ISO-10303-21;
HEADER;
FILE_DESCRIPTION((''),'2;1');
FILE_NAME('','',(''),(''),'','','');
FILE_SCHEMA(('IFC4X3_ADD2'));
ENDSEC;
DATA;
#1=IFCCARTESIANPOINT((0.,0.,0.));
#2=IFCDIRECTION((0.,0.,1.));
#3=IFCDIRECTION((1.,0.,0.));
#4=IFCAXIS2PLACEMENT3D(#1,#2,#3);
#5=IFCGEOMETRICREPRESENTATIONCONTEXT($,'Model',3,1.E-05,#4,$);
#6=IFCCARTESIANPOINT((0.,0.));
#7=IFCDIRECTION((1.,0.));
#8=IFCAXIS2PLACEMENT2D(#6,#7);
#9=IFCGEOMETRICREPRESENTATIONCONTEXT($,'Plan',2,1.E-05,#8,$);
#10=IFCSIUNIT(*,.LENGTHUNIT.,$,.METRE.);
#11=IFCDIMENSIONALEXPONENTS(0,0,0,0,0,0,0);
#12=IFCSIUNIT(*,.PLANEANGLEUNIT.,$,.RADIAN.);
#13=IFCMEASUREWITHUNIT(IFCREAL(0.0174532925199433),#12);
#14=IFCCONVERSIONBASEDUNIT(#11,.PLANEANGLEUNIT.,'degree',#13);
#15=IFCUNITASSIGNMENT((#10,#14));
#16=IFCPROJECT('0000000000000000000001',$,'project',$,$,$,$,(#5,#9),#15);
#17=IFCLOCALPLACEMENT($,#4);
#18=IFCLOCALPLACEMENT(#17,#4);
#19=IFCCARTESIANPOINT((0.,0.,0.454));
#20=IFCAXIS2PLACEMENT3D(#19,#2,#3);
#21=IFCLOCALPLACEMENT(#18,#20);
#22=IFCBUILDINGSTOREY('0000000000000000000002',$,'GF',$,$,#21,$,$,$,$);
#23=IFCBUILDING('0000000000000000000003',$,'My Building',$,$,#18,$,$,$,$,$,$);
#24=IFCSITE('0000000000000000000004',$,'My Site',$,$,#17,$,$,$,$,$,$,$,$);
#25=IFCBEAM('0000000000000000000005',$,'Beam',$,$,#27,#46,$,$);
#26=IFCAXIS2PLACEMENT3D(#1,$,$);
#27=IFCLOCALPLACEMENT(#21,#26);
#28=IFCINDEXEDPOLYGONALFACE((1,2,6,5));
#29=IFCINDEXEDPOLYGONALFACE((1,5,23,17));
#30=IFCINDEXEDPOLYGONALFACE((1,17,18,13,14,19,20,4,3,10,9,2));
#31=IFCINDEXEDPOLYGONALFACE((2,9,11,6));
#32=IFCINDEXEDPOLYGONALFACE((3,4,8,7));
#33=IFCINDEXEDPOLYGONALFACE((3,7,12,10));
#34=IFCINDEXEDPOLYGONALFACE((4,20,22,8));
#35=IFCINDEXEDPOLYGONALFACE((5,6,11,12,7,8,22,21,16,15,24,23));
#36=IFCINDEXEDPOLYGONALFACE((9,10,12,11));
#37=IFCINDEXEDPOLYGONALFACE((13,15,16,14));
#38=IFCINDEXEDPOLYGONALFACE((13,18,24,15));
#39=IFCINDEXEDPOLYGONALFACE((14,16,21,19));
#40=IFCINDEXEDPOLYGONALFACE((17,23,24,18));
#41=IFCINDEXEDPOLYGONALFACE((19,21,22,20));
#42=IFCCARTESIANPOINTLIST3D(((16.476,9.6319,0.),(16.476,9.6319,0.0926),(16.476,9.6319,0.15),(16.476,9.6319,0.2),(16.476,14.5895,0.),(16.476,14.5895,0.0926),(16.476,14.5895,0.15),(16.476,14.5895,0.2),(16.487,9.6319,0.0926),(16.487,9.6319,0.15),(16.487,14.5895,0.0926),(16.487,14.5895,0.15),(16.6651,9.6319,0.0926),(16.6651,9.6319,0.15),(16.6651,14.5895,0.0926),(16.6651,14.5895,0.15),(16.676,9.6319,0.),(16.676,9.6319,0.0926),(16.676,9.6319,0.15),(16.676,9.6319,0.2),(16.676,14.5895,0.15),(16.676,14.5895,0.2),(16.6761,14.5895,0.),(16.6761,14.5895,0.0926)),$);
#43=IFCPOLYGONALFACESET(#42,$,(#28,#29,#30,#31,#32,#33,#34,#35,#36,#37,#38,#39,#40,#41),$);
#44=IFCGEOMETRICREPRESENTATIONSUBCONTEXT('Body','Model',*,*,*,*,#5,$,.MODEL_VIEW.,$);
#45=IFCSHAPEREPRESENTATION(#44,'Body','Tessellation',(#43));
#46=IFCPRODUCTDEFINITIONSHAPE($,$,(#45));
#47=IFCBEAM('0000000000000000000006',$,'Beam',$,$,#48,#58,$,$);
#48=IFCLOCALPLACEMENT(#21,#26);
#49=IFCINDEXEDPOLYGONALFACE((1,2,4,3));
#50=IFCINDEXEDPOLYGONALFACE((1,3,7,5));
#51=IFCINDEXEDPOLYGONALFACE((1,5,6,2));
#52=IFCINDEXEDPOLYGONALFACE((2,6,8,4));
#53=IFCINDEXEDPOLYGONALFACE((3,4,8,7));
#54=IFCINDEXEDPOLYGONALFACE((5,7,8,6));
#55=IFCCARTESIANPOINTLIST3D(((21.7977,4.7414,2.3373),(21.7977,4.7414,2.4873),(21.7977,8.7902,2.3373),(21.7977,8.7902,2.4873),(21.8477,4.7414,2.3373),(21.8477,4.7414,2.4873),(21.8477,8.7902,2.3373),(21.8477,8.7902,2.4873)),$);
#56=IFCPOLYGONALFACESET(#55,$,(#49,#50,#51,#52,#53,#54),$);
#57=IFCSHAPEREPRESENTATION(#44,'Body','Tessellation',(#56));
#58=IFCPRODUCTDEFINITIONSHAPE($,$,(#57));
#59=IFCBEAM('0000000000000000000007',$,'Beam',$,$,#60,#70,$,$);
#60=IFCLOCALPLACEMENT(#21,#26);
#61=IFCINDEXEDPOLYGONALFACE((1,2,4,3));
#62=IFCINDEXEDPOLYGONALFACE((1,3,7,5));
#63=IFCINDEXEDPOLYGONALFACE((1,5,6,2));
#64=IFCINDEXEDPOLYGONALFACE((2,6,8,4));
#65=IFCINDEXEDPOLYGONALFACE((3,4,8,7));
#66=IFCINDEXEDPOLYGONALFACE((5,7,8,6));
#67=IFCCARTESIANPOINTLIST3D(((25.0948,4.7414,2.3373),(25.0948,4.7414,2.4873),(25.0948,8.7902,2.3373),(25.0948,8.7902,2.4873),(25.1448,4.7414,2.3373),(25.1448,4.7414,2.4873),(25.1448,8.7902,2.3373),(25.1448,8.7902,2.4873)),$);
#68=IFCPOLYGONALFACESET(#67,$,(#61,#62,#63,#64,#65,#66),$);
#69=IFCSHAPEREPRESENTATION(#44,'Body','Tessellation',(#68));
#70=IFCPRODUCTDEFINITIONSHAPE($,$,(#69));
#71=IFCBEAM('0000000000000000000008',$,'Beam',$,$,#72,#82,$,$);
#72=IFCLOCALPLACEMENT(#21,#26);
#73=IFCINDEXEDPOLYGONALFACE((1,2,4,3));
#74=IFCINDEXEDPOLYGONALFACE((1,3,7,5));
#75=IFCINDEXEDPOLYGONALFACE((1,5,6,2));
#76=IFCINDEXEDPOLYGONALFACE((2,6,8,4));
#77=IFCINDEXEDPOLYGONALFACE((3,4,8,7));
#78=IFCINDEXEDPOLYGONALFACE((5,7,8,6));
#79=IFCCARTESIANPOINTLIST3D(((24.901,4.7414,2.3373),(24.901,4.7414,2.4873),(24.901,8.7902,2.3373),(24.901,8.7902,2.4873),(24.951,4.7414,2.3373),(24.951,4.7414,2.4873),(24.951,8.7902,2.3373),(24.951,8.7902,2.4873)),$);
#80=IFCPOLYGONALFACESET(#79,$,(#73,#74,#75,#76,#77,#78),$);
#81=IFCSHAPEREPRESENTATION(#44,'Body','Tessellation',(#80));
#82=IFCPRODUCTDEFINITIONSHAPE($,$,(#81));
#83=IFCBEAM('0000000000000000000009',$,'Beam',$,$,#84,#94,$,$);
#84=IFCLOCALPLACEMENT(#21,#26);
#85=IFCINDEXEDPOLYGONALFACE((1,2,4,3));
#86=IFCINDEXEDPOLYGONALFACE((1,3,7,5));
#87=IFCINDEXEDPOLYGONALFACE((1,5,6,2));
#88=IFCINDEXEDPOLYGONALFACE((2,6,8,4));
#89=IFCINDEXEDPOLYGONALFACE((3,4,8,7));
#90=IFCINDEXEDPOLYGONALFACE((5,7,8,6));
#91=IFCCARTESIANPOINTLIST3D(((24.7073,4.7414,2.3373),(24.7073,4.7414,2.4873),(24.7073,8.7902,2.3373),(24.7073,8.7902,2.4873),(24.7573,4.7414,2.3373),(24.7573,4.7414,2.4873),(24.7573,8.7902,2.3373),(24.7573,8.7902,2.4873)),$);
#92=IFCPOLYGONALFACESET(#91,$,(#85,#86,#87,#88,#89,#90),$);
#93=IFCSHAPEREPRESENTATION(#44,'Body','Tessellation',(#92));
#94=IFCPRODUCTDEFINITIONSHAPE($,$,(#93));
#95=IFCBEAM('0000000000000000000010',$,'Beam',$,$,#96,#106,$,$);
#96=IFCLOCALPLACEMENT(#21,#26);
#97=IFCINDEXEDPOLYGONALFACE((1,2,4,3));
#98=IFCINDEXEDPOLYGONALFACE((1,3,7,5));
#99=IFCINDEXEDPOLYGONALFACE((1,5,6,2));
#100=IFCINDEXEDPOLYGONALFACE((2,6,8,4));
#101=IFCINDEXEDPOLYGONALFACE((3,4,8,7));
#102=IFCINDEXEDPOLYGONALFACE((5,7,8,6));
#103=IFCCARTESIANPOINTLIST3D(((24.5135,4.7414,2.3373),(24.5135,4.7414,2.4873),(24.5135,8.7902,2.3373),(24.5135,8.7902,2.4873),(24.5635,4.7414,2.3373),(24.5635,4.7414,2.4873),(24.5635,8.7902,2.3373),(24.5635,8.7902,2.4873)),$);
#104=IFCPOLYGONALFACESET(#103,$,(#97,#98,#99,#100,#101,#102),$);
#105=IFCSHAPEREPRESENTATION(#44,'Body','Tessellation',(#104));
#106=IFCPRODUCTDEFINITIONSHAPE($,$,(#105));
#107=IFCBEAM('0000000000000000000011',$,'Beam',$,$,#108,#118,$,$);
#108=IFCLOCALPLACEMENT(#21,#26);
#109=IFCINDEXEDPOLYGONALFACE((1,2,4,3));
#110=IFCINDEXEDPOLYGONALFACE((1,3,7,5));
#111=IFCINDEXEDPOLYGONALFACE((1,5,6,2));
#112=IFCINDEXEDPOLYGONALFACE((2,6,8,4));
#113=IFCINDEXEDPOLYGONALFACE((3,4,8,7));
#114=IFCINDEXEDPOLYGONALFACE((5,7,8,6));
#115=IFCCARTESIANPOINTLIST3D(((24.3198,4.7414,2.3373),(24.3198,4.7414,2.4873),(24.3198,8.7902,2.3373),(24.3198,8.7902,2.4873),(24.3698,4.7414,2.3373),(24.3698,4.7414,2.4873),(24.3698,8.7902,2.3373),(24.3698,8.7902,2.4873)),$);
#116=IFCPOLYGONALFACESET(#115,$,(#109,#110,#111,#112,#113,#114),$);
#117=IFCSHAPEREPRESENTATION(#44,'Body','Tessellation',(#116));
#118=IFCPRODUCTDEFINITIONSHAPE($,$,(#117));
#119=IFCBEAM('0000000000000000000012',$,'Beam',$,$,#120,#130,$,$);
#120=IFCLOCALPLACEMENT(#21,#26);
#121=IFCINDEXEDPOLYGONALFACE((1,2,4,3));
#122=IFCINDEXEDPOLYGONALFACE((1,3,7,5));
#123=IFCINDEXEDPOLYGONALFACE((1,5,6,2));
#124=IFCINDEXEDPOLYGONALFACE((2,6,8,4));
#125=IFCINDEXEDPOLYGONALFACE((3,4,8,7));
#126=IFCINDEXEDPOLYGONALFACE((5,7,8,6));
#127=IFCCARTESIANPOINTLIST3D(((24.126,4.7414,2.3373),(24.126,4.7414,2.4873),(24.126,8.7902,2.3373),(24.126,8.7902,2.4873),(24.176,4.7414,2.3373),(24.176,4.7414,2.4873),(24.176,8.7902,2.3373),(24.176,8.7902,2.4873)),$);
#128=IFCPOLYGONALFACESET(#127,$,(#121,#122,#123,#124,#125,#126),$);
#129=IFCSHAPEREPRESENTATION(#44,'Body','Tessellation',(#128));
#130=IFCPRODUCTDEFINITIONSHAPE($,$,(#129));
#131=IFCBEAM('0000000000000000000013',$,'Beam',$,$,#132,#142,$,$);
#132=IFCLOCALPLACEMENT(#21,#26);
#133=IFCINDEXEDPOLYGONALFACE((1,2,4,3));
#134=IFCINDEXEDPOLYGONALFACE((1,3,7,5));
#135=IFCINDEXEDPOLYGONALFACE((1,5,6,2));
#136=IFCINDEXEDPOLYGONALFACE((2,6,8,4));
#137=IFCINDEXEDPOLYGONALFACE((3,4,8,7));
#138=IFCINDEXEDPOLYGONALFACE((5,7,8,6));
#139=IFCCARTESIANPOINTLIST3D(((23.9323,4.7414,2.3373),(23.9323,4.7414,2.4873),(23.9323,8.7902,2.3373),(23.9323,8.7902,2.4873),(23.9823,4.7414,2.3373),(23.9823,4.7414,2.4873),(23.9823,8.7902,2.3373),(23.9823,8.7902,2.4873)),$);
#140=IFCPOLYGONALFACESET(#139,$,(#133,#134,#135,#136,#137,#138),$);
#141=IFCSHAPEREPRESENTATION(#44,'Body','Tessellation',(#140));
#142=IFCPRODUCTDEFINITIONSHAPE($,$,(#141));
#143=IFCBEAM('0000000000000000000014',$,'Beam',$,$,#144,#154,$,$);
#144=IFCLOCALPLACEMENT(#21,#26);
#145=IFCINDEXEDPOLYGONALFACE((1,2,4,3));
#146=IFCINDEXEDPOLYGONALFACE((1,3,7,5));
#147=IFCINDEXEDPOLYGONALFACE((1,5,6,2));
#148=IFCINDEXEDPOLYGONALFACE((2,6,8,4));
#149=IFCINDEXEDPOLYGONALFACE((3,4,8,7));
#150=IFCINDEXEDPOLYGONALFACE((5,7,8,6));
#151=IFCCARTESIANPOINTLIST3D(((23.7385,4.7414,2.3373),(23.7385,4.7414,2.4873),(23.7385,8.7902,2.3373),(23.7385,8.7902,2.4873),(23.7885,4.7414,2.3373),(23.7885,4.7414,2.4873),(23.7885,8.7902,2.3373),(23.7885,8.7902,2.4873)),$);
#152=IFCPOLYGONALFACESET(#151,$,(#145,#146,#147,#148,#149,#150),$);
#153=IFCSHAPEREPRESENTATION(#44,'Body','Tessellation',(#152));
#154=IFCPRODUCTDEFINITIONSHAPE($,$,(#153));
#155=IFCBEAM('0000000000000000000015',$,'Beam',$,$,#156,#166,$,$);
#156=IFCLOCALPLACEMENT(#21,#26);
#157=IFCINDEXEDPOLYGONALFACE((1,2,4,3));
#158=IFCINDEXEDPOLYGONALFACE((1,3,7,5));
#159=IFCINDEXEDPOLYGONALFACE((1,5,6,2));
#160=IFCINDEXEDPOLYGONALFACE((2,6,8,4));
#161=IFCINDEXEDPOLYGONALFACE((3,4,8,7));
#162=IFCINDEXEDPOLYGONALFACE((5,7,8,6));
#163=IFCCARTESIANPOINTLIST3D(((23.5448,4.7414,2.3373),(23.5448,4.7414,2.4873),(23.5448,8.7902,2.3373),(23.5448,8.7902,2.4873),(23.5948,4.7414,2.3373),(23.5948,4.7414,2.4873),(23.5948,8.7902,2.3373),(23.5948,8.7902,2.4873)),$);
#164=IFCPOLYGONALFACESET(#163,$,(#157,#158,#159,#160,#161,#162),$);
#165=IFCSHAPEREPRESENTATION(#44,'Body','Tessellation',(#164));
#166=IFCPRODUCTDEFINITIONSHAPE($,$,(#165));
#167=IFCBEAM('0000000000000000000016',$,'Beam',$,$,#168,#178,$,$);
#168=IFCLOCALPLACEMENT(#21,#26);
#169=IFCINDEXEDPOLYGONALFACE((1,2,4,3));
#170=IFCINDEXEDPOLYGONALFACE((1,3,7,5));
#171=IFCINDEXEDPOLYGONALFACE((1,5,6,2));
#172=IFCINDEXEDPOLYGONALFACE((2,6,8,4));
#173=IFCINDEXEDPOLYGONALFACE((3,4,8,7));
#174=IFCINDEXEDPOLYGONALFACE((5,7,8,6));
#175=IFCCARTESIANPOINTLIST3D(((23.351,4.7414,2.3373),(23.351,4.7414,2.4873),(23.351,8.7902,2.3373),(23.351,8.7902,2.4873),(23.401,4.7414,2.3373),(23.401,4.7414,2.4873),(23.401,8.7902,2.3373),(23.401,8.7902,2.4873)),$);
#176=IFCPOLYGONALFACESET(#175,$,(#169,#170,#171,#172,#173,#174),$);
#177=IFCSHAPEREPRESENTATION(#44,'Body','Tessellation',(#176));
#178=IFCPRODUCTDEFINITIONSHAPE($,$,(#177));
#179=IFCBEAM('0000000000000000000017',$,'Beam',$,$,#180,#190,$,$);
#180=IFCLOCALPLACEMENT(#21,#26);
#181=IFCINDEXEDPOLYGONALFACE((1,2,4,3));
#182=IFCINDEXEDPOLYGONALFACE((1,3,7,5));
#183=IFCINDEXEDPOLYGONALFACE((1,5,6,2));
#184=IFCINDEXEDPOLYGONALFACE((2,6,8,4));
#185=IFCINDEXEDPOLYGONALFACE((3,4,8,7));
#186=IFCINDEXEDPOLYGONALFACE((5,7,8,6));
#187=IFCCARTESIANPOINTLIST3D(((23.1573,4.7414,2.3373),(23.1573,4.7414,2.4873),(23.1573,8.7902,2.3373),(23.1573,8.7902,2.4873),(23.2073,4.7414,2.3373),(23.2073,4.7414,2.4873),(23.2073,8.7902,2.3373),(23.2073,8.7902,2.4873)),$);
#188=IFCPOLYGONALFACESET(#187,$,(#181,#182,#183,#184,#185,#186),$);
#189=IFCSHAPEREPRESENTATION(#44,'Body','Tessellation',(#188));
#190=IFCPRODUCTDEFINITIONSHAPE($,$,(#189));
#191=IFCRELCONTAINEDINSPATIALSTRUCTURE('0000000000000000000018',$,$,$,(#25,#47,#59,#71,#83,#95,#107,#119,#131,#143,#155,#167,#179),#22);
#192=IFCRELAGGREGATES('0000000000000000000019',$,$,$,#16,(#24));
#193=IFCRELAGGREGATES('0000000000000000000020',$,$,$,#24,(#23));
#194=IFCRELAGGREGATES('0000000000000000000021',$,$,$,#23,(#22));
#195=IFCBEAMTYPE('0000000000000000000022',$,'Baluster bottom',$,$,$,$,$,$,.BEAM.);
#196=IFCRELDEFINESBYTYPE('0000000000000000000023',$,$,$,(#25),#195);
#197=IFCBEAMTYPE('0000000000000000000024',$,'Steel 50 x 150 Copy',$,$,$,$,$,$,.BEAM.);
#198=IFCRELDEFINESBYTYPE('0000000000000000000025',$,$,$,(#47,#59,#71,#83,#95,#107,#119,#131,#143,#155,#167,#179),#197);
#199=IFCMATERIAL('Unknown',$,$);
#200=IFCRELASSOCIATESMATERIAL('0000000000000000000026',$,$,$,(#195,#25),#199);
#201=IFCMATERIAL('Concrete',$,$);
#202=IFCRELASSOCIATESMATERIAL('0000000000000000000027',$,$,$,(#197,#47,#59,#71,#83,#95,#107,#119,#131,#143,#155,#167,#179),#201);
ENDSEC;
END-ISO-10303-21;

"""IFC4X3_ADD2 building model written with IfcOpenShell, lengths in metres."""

from ifc_helpers import new_model, entity, si_unit, converted_unit, frame, origin_with_axes, origin_2d_with_axis, place, context, subcontext, project, spatial, indexed_curve, rectangle, outline, extrude, material, material_profile, profile_set, profile_usage, type_object, element, save


model = new_model("IFC4X3_ADD2")

# Units and contexts
model_context = context("Model", 3, precision=1e-05, world=origin_with_axes())
plan_context = context("Plan", 2, precision=1e-05, world=origin_2d_with_axis())
body_context_1 = subcontext(model_context, "Body", "Model", "MODEL_VIEW")
ifc_project = project(units=[si_unit("LENGTHUNIT", "METRE"), converted_unit("PLANEANGLEUNIT", "degree", entity("IfcReal", 0.0174532925199433), si_unit("PLANEANGLEUNIT", "RADIAN"), dimensions=[0, 0, 0, 0, 0, 0, 0])], contexts=[model_context, plan_context])

# Site, building, storey
site_placement = place(None, origin_with_axes())
site = spatial("IfcSite", under=ifc_project, at=site_placement, Name="My Site")
building_placement = place(site_placement, origin_with_axes())
building = spatial("IfcBuilding", under=site, at=building_placement, Name="My Building")
storey_placement = place(building_placement, frame((0.0, 0.0, 0.454), z_axis=(0.0, 0.0, 1.0), x_axis=(1.0, 0.0, 0.0)))
storey = spatial("IfcBuildingStorey", under=building, at=storey_placement, Name="GF")

# Beams
ifc_material_1 = material(Name="Unknown")
ifc_material_profile_1 = material_profile(ifc_material_1, outline(indexed_curve([(0.0891, 0.15), (0.1, 0.15), (0.1, 0.2), (-0.1, 0.2), (-0.1, 0.15), (-0.0891, 0.15), (-0.0891, 0.0926), (-0.1, 0.0926), (-0.1, 0.0), (0.1, 0.0), (0.1, 0.0926), (0.0891, 0.0926), (0.0891, 0.15)])))
ifc_profile_set_1 = profile_set([ifc_material_profile_1])
ifc_profile_usage_1 = profile_usage(ifc_profile_set_1, cardinal=5)
beam_type_1 = type_object("IfcBeamType", Name="Baluster bottom", PredefinedType="BEAM", material=ifc_profile_set_1)
beam_1_placement = place(storey_placement, frame((16.576, 14.5895, 0.0), z_axis=(0.0, -1.0, 0.0), x_axis=(1.0, 0.0, 0.0)))
element("IfcBeam", 1, at=beam_1_placement, inside=storey, type_object=beam_type_1, material=ifc_profile_usage_1, Name="Beam", context=body_context_1, shape_type="SweptSolid", body=[
    extrude(outline(indexed_curve([(0.0891, 0.15), (0.1, 0.15), (0.1, 0.2), (-0.1, 0.2), (-0.1, 0.15), (-0.0891, 0.15), (-0.0891, 0.0926), (-0.1, 0.0926), (-0.1, 0.0), (0.1, 0.0), (0.1, 0.0926), (0.0891, 0.0926), (0.0891, 0.15)])), origin_with_axes(), (0.0, 0.0, 1.0), 4.9577),
])
ifc_material_2 = material(Name="Concrete")
ifc_material_profile_2 = material_profile(ifc_material_2, rectangle(XDim=0.05, YDim=0.15))
ifc_profile_set_2 = profile_set([ifc_material_profile_2])
ifc_profile_usage_2 = profile_usage(ifc_profile_set_2)
beam_type_2 = type_object("IfcBeamType", Name="Steel 50 x 150 Copy", PredefinedType="BEAM", material=ifc_profile_set_2)
beam_2_placement = place(storey_placement, frame((21.8227, 8.7902, 2.4123), z_axis=(0.0, -1.0, 0.0), x_axis=(1.0, 0.0, 0.0)))
element("IfcBeam", 2, at=beam_2_placement, inside=storey, type_object=beam_type_2, material=ifc_profile_usage_2, Name="Beam", context=body_context_1, shape_type="SweptSolid", body=[
    extrude(rectangle(XDim=0.05, YDim=0.15), origin_with_axes(), (0.0, 0.0, 1.0), 4.0488),
])
ifc_profile_usage_3 = profile_usage(ifc_profile_set_2)
beam_3_placement = place(storey_placement, frame((25.1198, 8.7902, 2.4123), z_axis=(0.0, -1.0, 0.0), x_axis=(1.0, 0.0, 0.0)))
element("IfcBeam", 3, at=beam_3_placement, inside=storey, type_object=beam_type_2, material=ifc_profile_usage_3, Name="Beam", context=body_context_1, shape_type="SweptSolid", body=[
    extrude(rectangle(XDim=0.05, YDim=0.15), origin_with_axes(), (0.0, 0.0, 1.0), 4.0488),
])
ifc_profile_usage_4 = profile_usage(ifc_profile_set_2)
beam_4_placement = place(storey_placement, frame((24.926, 8.7902, 2.4123), z_axis=(0.0, -1.0, 0.0), x_axis=(1.0, 0.0, 0.0)))
element("IfcBeam", 4, at=beam_4_placement, inside=storey, type_object=beam_type_2, material=ifc_profile_usage_4, Name="Beam", context=body_context_1, shape_type="SweptSolid", body=[
    extrude(rectangle(XDim=0.05, YDim=0.15), origin_with_axes(), (0.0, 0.0, 1.0), 4.0488),
])
ifc_profile_usage_5 = profile_usage(ifc_profile_set_2)
beam_5_placement = place(storey_placement, frame((24.7323, 8.7902, 2.4123), z_axis=(0.0, -1.0, 0.0), x_axis=(1.0, 0.0, 0.0)))
element("IfcBeam", 5, at=beam_5_placement, inside=storey, type_object=beam_type_2, material=ifc_profile_usage_5, Name="Beam", context=body_context_1, shape_type="SweptSolid", body=[
    extrude(rectangle(XDim=0.05, YDim=0.15), origin_with_axes(), (0.0, 0.0, 1.0), 4.0488),
])
ifc_profile_usage_6 = profile_usage(ifc_profile_set_2)
beam_6_placement = place(storey_placement, frame((24.5385, 8.7902, 2.4123), z_axis=(0.0, -1.0, 0.0), x_axis=(1.0, 0.0, 0.0)))
element("IfcBeam", 6, at=beam_6_placement, inside=storey, type_object=beam_type_2, material=ifc_profile_usage_6, Name="Beam", context=body_context_1, shape_type="SweptSolid", body=[
    extrude(rectangle(XDim=0.05, YDim=0.15), origin_with_axes(), (0.0, 0.0, 1.0), 4.0488),
])
ifc_profile_usage_7 = profile_usage(ifc_profile_set_2)
beam_7_placement = place(storey_placement, frame((24.3448, 8.7902, 2.4123), z_axis=(0.0, -1.0, 0.0), x_axis=(1.0, 0.0, 0.0)))
element("IfcBeam", 7, at=beam_7_placement, inside=storey, type_object=beam_type_2, material=ifc_profile_usage_7, Name="Beam", context=body_context_1, shape_type="SweptSolid", body=[
    extrude(rectangle(XDim=0.05, YDim=0.15), origin_with_axes(), (0.0, 0.0, 1.0), 4.0488),
])
ifc_profile_usage_8 = profile_usage(ifc_profile_set_2)
beam_8_placement = place(storey_placement, frame((24.151, 8.7902, 2.4123), z_axis=(0.0, -1.0, 0.0), x_axis=(1.0, 0.0, 0.0)))
element("IfcBeam", 8, at=beam_8_placement, inside=storey, type_object=beam_type_2, material=ifc_profile_usage_8, Name="Beam", context=body_context_1, shape_type="SweptSolid", body=[
    extrude(rectangle(XDim=0.05, YDim=0.15), origin_with_axes(), (0.0, 0.0, 1.0), 4.0488),
])
ifc_profile_usage_9 = profile_usage(ifc_profile_set_2)
beam_9_placement = place(storey_placement, frame((23.9573, 8.7902, 2.4123), z_axis=(0.0, -1.0, 0.0), x_axis=(1.0, 0.0, 0.0)))
element("IfcBeam", 9, at=beam_9_placement, inside=storey, type_object=beam_type_2, material=ifc_profile_usage_9, Name="Beam", context=body_context_1, shape_type="SweptSolid", body=[
    extrude(rectangle(XDim=0.05, YDim=0.15), origin_with_axes(), (0.0, 0.0, 1.0), 4.0488),
])
ifc_profile_usage_10 = profile_usage(ifc_profile_set_2)
beam_10_placement = place(storey_placement, frame((23.7635, 8.7902, 2.4123), z_axis=(0.0, -1.0, 0.0), x_axis=(1.0, 0.0, 0.0)))
element("IfcBeam", 10, at=beam_10_placement, inside=storey, type_object=beam_type_2, material=ifc_profile_usage_10, Name="Beam", context=body_context_1, shape_type="SweptSolid", body=[
    extrude(rectangle(XDim=0.05, YDim=0.15), origin_with_axes(), (0.0, 0.0, 1.0), 4.0488),
])
ifc_profile_usage_11 = profile_usage(ifc_profile_set_2)
beam_11_placement = place(storey_placement, frame((23.5698, 8.7902, 2.4123), z_axis=(0.0, -1.0, 0.0), x_axis=(1.0, 0.0, 0.0)))
element("IfcBeam", 11, at=beam_11_placement, inside=storey, type_object=beam_type_2, material=ifc_profile_usage_11, Name="Beam", context=body_context_1, shape_type="SweptSolid", body=[
    extrude(rectangle(XDim=0.05, YDim=0.15), origin_with_axes(), (0.0, 0.0, 1.0), 4.0488),
])
ifc_profile_usage_12 = profile_usage(ifc_profile_set_2)
beam_12_placement = place(storey_placement, frame((23.376, 8.7902, 2.4123), z_axis=(0.0, -1.0, 0.0), x_axis=(1.0, 0.0, 0.0)))
element("IfcBeam", 12, at=beam_12_placement, inside=storey, type_object=beam_type_2, material=ifc_profile_usage_12, Name="Beam", context=body_context_1, shape_type="SweptSolid", body=[
    extrude(rectangle(XDim=0.05, YDim=0.15), origin_with_axes(), (0.0, 0.0, 1.0), 4.0488),
])
ifc_profile_usage_13 = profile_usage(ifc_profile_set_2)
beam_13_placement = place(storey_placement, frame((23.1823, 8.7902, 2.4123), z_axis=(0.0, -1.0, 0.0), x_axis=(1.0, 0.0, 0.0)))
element("IfcBeam", 13, at=beam_13_placement, inside=storey, type_object=beam_type_2, material=ifc_profile_usage_13, Name="Beam", context=body_context_1, shape_type="SweptSolid", body=[
    extrude(rectangle(XDim=0.05, YDim=0.15), origin_with_axes(), (0.0, 0.0, 1.0), 4.0488),
])

save(model, "model.ifc")
